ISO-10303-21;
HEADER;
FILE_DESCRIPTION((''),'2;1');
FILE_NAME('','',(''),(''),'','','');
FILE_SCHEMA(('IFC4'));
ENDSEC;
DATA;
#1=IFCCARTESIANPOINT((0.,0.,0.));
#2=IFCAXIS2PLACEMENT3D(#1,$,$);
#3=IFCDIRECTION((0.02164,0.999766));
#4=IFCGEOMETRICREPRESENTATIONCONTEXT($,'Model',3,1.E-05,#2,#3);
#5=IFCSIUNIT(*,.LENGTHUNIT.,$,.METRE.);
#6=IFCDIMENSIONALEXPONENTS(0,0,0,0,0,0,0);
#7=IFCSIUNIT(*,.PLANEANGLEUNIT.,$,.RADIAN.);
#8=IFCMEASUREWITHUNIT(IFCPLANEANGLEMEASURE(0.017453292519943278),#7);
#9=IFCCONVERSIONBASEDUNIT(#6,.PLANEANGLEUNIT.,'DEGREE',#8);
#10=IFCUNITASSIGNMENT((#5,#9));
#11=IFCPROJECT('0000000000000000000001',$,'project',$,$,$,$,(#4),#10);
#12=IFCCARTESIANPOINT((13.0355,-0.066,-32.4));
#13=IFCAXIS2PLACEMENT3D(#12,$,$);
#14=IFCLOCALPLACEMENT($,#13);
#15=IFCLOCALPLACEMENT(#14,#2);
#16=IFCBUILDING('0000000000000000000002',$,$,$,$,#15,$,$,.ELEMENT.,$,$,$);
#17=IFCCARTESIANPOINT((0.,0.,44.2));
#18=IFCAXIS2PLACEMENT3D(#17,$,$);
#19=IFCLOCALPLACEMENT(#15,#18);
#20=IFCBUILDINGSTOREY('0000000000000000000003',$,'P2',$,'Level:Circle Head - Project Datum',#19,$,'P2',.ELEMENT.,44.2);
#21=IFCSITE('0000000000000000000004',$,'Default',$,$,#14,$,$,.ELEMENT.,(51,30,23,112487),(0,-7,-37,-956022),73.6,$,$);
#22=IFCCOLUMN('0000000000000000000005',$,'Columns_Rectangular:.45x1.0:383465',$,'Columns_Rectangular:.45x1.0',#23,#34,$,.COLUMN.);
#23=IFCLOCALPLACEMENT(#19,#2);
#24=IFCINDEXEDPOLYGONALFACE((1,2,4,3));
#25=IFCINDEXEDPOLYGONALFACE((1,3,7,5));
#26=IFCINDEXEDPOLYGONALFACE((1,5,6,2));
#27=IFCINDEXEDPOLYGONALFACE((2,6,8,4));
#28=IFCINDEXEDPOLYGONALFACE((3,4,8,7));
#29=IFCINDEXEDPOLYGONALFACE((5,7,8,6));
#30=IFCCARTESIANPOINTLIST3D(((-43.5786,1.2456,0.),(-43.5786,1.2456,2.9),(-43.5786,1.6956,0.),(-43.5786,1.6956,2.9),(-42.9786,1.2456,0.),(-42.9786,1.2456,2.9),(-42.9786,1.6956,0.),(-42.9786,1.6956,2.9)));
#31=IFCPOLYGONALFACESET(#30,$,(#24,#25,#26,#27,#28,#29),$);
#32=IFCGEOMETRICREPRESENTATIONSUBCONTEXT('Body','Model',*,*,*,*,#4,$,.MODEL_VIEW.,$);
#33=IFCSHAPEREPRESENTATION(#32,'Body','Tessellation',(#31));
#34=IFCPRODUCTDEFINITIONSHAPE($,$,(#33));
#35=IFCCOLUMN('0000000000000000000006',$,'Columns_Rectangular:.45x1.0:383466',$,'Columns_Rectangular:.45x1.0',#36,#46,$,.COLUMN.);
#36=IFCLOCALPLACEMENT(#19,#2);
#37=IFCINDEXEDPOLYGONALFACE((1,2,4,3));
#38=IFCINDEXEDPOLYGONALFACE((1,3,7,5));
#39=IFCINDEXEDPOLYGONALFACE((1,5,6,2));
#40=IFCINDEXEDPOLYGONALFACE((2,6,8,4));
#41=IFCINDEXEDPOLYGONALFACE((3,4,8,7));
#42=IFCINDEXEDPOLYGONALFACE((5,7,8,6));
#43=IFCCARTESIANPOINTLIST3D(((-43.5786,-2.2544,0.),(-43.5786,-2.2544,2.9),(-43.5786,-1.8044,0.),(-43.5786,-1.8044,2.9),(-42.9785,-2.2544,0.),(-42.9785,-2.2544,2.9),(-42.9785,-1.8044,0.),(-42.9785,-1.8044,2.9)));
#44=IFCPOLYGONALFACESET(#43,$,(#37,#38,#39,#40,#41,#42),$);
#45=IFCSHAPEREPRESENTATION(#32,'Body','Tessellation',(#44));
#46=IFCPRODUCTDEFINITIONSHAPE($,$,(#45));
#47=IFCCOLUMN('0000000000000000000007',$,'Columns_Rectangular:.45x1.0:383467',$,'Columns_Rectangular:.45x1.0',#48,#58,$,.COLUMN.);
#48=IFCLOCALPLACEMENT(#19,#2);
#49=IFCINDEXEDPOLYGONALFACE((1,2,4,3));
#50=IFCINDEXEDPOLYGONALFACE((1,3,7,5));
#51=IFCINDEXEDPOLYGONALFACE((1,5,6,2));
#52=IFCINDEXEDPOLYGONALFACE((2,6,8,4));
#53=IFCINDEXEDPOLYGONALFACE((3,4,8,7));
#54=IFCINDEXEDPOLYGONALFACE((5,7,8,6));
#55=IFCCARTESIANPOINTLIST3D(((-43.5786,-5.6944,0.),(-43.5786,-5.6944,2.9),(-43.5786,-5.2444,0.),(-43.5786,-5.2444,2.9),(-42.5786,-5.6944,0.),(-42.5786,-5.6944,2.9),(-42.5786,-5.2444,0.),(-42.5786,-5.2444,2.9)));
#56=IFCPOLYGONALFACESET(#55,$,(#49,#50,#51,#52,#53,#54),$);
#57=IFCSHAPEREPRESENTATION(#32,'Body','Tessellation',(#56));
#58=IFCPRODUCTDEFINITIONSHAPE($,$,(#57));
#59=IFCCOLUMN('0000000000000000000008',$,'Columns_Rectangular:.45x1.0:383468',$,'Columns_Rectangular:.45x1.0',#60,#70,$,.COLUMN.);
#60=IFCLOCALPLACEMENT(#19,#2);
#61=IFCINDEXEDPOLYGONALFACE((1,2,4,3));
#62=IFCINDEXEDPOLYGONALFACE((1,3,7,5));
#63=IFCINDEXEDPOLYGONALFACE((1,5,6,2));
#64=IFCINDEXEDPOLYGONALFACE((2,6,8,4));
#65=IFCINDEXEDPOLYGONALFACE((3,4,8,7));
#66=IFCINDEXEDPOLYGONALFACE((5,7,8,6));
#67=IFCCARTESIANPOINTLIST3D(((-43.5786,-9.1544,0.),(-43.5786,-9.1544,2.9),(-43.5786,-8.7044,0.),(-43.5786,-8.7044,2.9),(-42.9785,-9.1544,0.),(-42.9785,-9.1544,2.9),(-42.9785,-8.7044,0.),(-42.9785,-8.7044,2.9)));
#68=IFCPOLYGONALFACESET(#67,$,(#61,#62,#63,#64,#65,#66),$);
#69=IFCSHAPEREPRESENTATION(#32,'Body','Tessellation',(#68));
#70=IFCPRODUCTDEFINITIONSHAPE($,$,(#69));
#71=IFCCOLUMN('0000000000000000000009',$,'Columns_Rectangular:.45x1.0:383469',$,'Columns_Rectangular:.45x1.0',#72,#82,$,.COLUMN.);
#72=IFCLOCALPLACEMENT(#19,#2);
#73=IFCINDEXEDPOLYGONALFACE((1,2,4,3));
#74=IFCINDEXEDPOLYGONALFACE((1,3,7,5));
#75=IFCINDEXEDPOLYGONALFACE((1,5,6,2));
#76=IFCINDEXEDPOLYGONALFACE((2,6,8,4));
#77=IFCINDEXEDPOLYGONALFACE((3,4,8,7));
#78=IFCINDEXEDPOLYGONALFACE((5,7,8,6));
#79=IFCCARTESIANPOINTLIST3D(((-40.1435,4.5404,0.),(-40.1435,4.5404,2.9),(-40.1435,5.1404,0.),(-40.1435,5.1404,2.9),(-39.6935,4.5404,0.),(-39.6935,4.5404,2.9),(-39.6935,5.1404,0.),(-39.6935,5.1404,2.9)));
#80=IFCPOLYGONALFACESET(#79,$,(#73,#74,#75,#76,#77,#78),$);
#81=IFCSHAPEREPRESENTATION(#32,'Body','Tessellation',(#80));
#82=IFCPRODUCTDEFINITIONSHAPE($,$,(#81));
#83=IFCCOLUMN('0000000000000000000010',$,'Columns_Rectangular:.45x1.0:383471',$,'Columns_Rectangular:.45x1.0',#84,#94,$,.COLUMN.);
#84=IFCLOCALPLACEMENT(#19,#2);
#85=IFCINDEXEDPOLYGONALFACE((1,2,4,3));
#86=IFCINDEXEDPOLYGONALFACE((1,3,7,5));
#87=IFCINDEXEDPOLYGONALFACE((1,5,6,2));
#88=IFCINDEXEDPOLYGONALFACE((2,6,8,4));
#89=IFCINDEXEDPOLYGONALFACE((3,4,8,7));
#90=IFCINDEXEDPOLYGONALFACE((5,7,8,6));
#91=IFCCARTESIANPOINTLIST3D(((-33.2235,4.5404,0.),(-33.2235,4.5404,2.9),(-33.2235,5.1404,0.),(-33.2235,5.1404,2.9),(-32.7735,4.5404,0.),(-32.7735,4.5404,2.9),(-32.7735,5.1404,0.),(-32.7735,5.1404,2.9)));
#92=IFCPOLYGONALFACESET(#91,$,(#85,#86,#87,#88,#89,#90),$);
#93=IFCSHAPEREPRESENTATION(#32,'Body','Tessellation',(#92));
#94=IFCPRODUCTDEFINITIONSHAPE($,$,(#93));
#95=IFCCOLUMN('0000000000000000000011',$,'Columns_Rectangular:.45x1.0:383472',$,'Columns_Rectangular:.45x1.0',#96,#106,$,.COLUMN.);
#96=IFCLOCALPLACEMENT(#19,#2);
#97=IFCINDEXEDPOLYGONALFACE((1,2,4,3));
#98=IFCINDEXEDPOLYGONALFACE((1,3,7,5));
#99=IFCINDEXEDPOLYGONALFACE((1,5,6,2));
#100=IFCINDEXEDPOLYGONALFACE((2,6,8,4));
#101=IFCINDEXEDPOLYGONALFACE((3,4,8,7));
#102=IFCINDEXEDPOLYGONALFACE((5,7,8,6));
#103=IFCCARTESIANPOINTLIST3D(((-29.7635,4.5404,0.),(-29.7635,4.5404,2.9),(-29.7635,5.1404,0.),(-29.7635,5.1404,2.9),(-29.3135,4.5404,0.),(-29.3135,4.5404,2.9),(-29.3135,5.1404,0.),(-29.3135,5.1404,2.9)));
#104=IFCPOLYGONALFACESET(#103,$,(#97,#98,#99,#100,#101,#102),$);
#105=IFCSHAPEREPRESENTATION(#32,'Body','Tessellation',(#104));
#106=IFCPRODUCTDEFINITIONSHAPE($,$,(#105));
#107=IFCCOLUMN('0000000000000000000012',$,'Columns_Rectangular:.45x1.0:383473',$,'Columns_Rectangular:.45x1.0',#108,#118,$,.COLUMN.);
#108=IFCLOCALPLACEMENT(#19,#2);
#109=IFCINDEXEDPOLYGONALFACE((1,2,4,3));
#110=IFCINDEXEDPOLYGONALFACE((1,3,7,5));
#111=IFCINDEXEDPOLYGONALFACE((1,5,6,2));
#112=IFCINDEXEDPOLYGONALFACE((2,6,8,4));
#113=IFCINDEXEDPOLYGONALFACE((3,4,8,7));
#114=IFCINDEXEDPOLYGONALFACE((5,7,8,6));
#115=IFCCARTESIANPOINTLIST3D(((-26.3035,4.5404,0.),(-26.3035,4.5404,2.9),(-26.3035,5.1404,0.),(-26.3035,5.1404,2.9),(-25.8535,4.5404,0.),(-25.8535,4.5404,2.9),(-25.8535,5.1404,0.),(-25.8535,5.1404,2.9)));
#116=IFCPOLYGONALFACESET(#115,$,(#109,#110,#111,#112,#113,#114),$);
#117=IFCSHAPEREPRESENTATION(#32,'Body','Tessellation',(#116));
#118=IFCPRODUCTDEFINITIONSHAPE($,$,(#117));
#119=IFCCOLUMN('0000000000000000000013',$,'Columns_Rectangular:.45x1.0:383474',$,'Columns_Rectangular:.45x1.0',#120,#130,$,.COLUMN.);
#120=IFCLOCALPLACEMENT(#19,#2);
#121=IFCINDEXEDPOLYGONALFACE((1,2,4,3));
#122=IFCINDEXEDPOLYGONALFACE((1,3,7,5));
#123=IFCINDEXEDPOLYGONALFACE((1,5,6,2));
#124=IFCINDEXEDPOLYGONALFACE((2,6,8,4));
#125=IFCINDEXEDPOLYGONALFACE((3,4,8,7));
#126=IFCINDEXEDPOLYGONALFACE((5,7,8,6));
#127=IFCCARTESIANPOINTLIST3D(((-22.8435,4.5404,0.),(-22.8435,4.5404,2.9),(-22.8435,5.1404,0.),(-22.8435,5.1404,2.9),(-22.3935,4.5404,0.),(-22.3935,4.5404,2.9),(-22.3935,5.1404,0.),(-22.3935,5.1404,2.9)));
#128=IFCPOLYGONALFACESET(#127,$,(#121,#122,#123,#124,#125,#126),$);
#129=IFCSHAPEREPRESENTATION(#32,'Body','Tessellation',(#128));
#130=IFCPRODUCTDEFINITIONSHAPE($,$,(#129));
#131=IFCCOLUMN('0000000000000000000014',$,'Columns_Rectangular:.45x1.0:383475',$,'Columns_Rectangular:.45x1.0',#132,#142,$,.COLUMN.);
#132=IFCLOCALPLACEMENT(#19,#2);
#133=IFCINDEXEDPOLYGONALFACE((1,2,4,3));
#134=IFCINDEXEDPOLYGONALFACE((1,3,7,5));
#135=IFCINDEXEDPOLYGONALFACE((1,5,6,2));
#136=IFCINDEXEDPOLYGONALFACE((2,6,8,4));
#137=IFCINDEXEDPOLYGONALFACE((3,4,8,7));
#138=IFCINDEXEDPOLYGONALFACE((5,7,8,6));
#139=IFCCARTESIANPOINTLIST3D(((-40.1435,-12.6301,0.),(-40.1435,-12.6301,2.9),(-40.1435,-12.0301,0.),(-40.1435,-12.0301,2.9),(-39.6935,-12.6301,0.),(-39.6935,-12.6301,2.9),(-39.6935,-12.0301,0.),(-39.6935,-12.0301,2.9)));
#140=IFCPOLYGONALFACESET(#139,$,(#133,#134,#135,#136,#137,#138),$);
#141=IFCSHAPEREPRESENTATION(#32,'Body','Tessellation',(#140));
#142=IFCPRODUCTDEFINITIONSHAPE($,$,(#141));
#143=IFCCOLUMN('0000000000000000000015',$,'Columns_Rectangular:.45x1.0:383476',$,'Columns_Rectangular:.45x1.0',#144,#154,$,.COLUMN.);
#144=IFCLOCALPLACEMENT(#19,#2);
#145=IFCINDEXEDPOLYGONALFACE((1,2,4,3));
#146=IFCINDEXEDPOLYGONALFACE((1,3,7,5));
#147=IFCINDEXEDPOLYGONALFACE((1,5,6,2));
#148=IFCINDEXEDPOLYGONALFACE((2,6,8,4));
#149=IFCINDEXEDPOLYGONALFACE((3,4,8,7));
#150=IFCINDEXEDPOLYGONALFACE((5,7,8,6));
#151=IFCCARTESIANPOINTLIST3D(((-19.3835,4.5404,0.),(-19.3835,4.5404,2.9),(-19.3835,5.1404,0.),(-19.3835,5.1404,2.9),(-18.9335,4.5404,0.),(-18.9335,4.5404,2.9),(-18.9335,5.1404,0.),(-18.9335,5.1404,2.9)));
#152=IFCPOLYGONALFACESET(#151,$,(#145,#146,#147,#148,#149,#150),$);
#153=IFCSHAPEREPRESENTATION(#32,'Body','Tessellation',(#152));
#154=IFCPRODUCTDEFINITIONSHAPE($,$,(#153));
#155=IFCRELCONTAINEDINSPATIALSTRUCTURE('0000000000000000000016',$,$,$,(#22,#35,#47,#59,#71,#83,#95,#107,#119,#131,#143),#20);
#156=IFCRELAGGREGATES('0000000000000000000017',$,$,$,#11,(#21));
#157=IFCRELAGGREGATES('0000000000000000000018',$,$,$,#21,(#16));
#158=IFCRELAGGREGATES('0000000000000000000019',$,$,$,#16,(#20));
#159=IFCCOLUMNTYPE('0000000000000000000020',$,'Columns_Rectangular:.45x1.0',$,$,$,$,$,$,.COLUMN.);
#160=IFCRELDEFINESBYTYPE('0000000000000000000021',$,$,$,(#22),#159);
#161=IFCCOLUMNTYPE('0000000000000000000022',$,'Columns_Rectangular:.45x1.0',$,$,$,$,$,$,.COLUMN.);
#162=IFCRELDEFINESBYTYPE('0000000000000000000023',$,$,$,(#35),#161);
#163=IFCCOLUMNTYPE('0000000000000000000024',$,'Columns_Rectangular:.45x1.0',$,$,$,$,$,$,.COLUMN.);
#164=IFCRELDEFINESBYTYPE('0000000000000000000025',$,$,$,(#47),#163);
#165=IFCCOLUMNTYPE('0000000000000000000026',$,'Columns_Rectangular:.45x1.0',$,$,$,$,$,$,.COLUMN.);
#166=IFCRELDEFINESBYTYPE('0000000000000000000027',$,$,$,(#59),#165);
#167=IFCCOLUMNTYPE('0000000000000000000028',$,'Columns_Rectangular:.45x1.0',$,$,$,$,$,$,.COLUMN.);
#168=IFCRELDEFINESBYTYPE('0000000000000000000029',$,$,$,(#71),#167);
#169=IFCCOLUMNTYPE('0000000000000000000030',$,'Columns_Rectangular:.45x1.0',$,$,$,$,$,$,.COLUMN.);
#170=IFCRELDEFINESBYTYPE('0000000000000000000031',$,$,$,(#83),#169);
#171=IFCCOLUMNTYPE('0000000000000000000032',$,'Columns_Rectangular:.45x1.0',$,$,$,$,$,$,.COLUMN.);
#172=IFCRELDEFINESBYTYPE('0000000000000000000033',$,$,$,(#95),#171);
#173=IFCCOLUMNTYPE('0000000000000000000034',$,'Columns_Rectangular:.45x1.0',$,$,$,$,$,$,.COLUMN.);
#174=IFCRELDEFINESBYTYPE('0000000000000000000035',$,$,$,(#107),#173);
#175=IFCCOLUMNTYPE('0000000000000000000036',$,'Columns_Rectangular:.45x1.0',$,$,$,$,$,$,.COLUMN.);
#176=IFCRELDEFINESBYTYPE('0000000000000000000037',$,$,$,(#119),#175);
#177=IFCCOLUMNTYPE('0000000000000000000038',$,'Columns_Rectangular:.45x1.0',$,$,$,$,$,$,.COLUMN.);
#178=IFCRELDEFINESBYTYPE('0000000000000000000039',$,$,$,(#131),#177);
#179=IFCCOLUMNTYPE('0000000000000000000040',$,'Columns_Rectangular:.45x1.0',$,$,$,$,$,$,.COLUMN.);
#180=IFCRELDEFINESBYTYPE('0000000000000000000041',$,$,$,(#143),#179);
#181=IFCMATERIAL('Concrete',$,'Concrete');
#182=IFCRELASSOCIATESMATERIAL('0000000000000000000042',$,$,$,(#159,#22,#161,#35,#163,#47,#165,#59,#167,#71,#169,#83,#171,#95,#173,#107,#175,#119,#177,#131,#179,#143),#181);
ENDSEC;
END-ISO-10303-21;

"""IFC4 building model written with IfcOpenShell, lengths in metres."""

from ifc_helpers import new_model, entity, si_unit, converted_unit, direction, frame, origin, place, context, subcontext, project, spatial, indexed_curve, outline, extrude, source, transform, mapped, material, type_object, type_shapes, element, save


model = new_model("IFC4")

# Units and contexts
model_context = context("Model", 3, precision=1e-05, world=origin(), true_north=direction((0.02164, 0.999766)))
body_context = subcontext(model_context, "Body", "Model", "MODEL_VIEW")
ifc_project = project(units=[si_unit("LENGTHUNIT", "METRE"), converted_unit("PLANEANGLEUNIT", "DEGREE", entity("IfcPlaneAngleMeasure", 0.017453292519943278), si_unit("PLANEANGLEUNIT", "RADIAN"), dimensions=[0, 0, 0, 0, 0, 0, 0])], contexts=[model_context])

# Site, building, storey
site_placement = place(None, frame((13.0355, -0.066, -32.4)))
site = spatial("IfcSite", under=ifc_project, at=site_placement, Name="Default", CompositionType="ELEMENT", RefLatitude=(51, 30, 23, 112487), RefLongitude=(0, -7, -37, -956022), RefElevation=73.6)
building_placement = place(site_placement, origin())
building = spatial("IfcBuilding", under=site, at=building_placement, CompositionType="ELEMENT")
storey_placement = place(building_placement, frame((0.0, 0.0, 44.2)))
storey = spatial("IfcBuildingStorey", under=building, at=storey_placement, Name="P2", ObjectType="Level:Circle Head - Project Datum", LongName="P2", CompositionType="ELEMENT", Elevation=44.2)

# Columns
ifc_material = material(Name="Concrete", Category="Concrete")
column_type_1 = type_object("IfcColumnType", Name="Columns_Rectangular:.45x1.0", PredefinedType="COLUMN", material=ifc_material)
shared_shape_1 = source(origin(), body_context, "Body", "SweptSolid", [
    extrude(outline(indexed_curve([(-0.3, -0.225), (0.3, -0.225), (0.3, 0.225), (-0.3, 0.225), (-0.3, -0.225)], self_intersect=False)), frame((-43.2786, 1.4706, 44.2)), (0.0, 0.0, 1.0), 2.9),
])
type_shapes(column_type_1, [shared_shape_1])
column_1_placement = place(storey_placement, frame((0.0, 0.0, -44.2)))
element("IfcColumn", 1, at=column_1_placement, inside=storey, type_object=column_type_1, material=ifc_material, Name="Columns_Rectangular:.45x1.0:383465", ObjectType="Columns_Rectangular:.45x1.0", PredefinedType="COLUMN", context=body_context, shape_type="MappedRepresentation", body=[
    mapped(shared_shape_1, transform((0.0, 0.0, 0.0), scale=1.0)),
])
column_type_2 = type_object("IfcColumnType", Name="Columns_Rectangular:.45x1.0", PredefinedType="COLUMN", material=ifc_material)
shared_shape_2 = source(origin(), body_context, "Body", "SweptSolid", [
    extrude(outline(indexed_curve([(-0.3, -0.225), (0.3, -0.225), (0.3, 0.225), (-0.3, 0.225), (-0.3, -0.225)], self_intersect=False)), frame((-43.2785, -2.0294, 44.2)), (0.0, 0.0, 1.0), 2.9),
])
type_shapes(column_type_2, [shared_shape_2])
column_2_placement = place(storey_placement, frame((0.0, 0.0, -44.2)))
element("IfcColumn", 2, at=column_2_placement, inside=storey, type_object=column_type_2, material=ifc_material, Name="Columns_Rectangular:.45x1.0:383466", ObjectType="Columns_Rectangular:.45x1.0", PredefinedType="COLUMN", context=body_context, shape_type="MappedRepresentation", body=[
    mapped(shared_shape_2, transform((0.0, 0.0, 0.0), scale=1.0)),
])
column_type_3 = type_object("IfcColumnType", Name="Columns_Rectangular:.45x1.0", PredefinedType="COLUMN", material=ifc_material)
shared_shape_3 = source(origin(), body_context, "Body", "SweptSolid", [
    extrude(outline(indexed_curve([(-0.5, -0.225), (0.5, -0.225), (0.5, 0.225), (-0.5, 0.225), (-0.5, -0.225)], self_intersect=False)), frame((-43.0786, -5.4694, 44.2), z_axis=(0.0, 0.0, 1.0), x_axis=(-1.0, 0.0, 0.0)), (0.0, 0.0, 1.0), 2.9),
])
type_shapes(column_type_3, [shared_shape_3])
column_3_placement = place(storey_placement, frame((0.0, 0.0, -44.2)))
element("IfcColumn", 3, at=column_3_placement, inside=storey, type_object=column_type_3, material=ifc_material, Name="Columns_Rectangular:.45x1.0:383467", ObjectType="Columns_Rectangular:.45x1.0", PredefinedType="COLUMN", context=body_context, shape_type="MappedRepresentation", body=[
    mapped(shared_shape_3, transform((0.0, 0.0, 0.0), scale=1.0)),
])
column_type_4 = type_object("IfcColumnType", Name="Columns_Rectangular:.45x1.0", PredefinedType="COLUMN", material=ifc_material)
shared_shape_4 = source(origin(), body_context, "Body", "SweptSolid", [
    extrude(outline(indexed_curve([(-0.3, -0.225), (0.3, -0.225), (0.3, 0.225), (-0.3, 0.225), (-0.3, -0.225)], self_intersect=False)), frame((-43.2785, -8.9294, 44.2)), (0.0, 0.0, 1.0), 2.9),
])
type_shapes(column_type_4, [shared_shape_4])
column_4_placement = place(storey_placement, frame((0.0, 0.0, -44.2)))
element("IfcColumn", 4, at=column_4_placement, inside=storey, type_object=column_type_4, material=ifc_material, Name="Columns_Rectangular:.45x1.0:383468", ObjectType="Columns_Rectangular:.45x1.0", PredefinedType="COLUMN", context=body_context, shape_type="MappedRepresentation", body=[
    mapped(shared_shape_4, transform((0.0, 0.0, 0.0), scale=1.0)),
])
column_type_5 = type_object("IfcColumnType", Name="Columns_Rectangular:.45x1.0", PredefinedType="COLUMN", material=ifc_material)
shared_shape_5 = source(origin(), body_context, "Body", "SweptSolid", [
    extrude(outline(indexed_curve([(-0.3, -0.225), (0.3, -0.225), (0.3, 0.225), (-0.3, 0.225), (-0.3, -0.225)], self_intersect=False)), frame((-39.9185, 4.8404, 44.2), z_axis=(0.0, 0.0, 1.0), x_axis=(0.0, -1.0, 0.0)), (0.0, 0.0, 1.0), 2.9),
])
type_shapes(column_type_5, [shared_shape_5])
column_5_placement = place(storey_placement, frame((0.0, 0.0, -44.2)))
element("IfcColumn", 5, at=column_5_placement, inside=storey, type_object=column_type_5, material=ifc_material, Name="Columns_Rectangular:.45x1.0:383469", ObjectType="Columns_Rectangular:.45x1.0", PredefinedType="COLUMN", context=body_context, shape_type="MappedRepresentation", body=[
    mapped(shared_shape_5, transform((0.0, 0.0, 0.0), scale=1.0)),
])
column_type_6 = type_object("IfcColumnType", Name="Columns_Rectangular:.45x1.0", PredefinedType="COLUMN", material=ifc_material)
shared_shape_6 = source(origin(), body_context, "Body", "SweptSolid", [
    extrude(outline(indexed_curve([(-0.3, -0.225), (0.3, -0.225), (0.3, 0.225), (-0.3, 0.225), (-0.3, -0.225)], self_intersect=False)), frame((-32.9985, 4.8404, 44.2), z_axis=(0.0, 0.0, 1.0), x_axis=(0.0, -1.0, 0.0)), (0.0, 0.0, 1.0), 2.9),
])
type_shapes(column_type_6, [shared_shape_6])
column_6_placement = place(storey_placement, frame((0.0, 0.0, -44.2)))
element("IfcColumn", 6, at=column_6_placement, inside=storey, type_object=column_type_6, material=ifc_material, Name="Columns_Rectangular:.45x1.0:383471", ObjectType="Columns_Rectangular:.45x1.0", PredefinedType="COLUMN", context=body_context, shape_type="MappedRepresentation", body=[
    mapped(shared_shape_6, transform((0.0, 0.0, 0.0), scale=1.0)),
])
column_type_7 = type_object("IfcColumnType", Name="Columns_Rectangular:.45x1.0", PredefinedType="COLUMN", material=ifc_material)
shared_shape_7 = source(origin(), body_context, "Body", "SweptSolid", [
    extrude(outline(indexed_curve([(-0.3, -0.225), (0.3, -0.225), (0.3, 0.225), (-0.3, 0.225), (-0.3, -0.225)], self_intersect=False)), frame((-29.5385, 4.8404, 44.2), z_axis=(0.0, 0.0, 1.0), x_axis=(0.0, -1.0, 0.0)), (0.0, 0.0, 1.0), 2.9),
])
type_shapes(column_type_7, [shared_shape_7])
column_7_placement = place(storey_placement, frame((0.0, 0.0, -44.2)))
element("IfcColumn", 7, at=column_7_placement, inside=storey, type_object=column_type_7, material=ifc_material, Name="Columns_Rectangular:.45x1.0:383472", ObjectType="Columns_Rectangular:.45x1.0", PredefinedType="COLUMN", context=body_context, shape_type="MappedRepresentation", body=[
    mapped(shared_shape_7, transform((0.0, 0.0, 0.0), scale=1.0)),
])
column_type_8 = type_object("IfcColumnType", Name="Columns_Rectangular:.45x1.0", PredefinedType="COLUMN", material=ifc_material)
shared_shape_8 = source(origin(), body_context, "Body", "SweptSolid", [
    extrude(outline(indexed_curve([(-0.3, -0.225), (0.3, -0.225), (0.3, 0.225), (-0.3, 0.225), (-0.3, -0.225)], self_intersect=False)), frame((-26.0785, 4.8404, 44.2), z_axis=(0.0, 0.0, 1.0), x_axis=(0.0, -1.0, 0.0)), (0.0, 0.0, 1.0), 2.9),
])
type_shapes(column_type_8, [shared_shape_8])
column_8_placement = place(storey_placement, frame((0.0, 0.0, -44.2)))
element("IfcColumn", 8, at=column_8_placement, inside=storey, type_object=column_type_8, material=ifc_material, Name="Columns_Rectangular:.45x1.0:383473", ObjectType="Columns_Rectangular:.45x1.0", PredefinedType="COLUMN", context=body_context, shape_type="MappedRepresentation", body=[
    mapped(shared_shape_8, transform((0.0, 0.0, 0.0), scale=1.0)),
])
column_type_9 = type_object("IfcColumnType", Name="Columns_Rectangular:.45x1.0", PredefinedType="COLUMN", material=ifc_material)
shared_shape_9 = source(origin(), body_context, "Body", "SweptSolid", [
    extrude(outline(indexed_curve([(-0.3, -0.225), (0.3, -0.225), (0.3, 0.225), (-0.3, 0.225), (-0.3, -0.225)], self_intersect=False)), frame((-22.6185, 4.8404, 44.2), z_axis=(0.0, 0.0, 1.0), x_axis=(0.0, -1.0, 0.0)), (0.0, 0.0, 1.0), 2.9),
])
type_shapes(column_type_9, [shared_shape_9])
column_9_placement = place(storey_placement, frame((0.0, 0.0, -44.2)))
element("IfcColumn", 9, at=column_9_placement, inside=storey, type_object=column_type_9, material=ifc_material, Name="Columns_Rectangular:.45x1.0:383474", ObjectType="Columns_Rectangular:.45x1.0", PredefinedType="COLUMN", context=body_context, shape_type="MappedRepresentation", body=[
    mapped(shared_shape_9, transform((0.0, 0.0, 0.0), scale=1.0)),
])
column_type_10 = type_object("IfcColumnType", Name="Columns_Rectangular:.45x1.0", PredefinedType="COLUMN", material=ifc_material)
shared_shape_10 = source(origin(), body_context, "Body", "SweptSolid", [
    extrude(outline(indexed_curve([(-0.3, -0.225), (0.3, -0.225), (0.3, 0.225), (-0.3, 0.225), (-0.3, -0.225)], self_intersect=False)), frame((-39.9185, -12.3301, 44.2), z_axis=(0.0, 0.0, 1.0), x_axis=(0.000011, 1.0, 0.0)), (0.0, 0.0, 1.0), 2.9),
])
type_shapes(column_type_10, [shared_shape_10])
column_10_placement = place(storey_placement, frame((0.0, 0.0, -44.2)))
element("IfcColumn", 10, at=column_10_placement, inside=storey, type_object=column_type_10, material=ifc_material, Name="Columns_Rectangular:.45x1.0:383475", ObjectType="Columns_Rectangular:.45x1.0", PredefinedType="COLUMN", context=body_context, shape_type="MappedRepresentation", body=[
    mapped(shared_shape_10, transform((0.0, 0.0, 0.0), scale=1.0)),
])
column_type_11 = type_object("IfcColumnType", Name="Columns_Rectangular:.45x1.0", PredefinedType="COLUMN", material=ifc_material)
shared_shape_11 = source(origin(), body_context, "Body", "SweptSolid", [
    extrude(outline(indexed_curve([(-0.3, -0.225), (0.3, -0.225), (0.3, 0.225), (-0.3, 0.225), (-0.3, -0.225)], self_intersect=False)), frame((-19.1585, 4.8404, 44.2), z_axis=(0.0, 0.0, 1.0), x_axis=(0.0, -1.0, 0.0)), (0.0, 0.0, 1.0), 2.9),
])
type_shapes(column_type_11, [shared_shape_11])
column_11_placement = place(storey_placement, frame((0.0, 0.0, -44.2)))
element("IfcColumn", 11, at=column_11_placement, inside=storey, type_object=column_type_11, material=ifc_material, Name="Columns_Rectangular:.45x1.0:383476", ObjectType="Columns_Rectangular:.45x1.0", PredefinedType="COLUMN", context=body_context, shape_type="MappedRepresentation", body=[
    mapped(shared_shape_11, transform((0.0, 0.0, 0.0), scale=1.0)),
])

save(model, "model.ifc")
